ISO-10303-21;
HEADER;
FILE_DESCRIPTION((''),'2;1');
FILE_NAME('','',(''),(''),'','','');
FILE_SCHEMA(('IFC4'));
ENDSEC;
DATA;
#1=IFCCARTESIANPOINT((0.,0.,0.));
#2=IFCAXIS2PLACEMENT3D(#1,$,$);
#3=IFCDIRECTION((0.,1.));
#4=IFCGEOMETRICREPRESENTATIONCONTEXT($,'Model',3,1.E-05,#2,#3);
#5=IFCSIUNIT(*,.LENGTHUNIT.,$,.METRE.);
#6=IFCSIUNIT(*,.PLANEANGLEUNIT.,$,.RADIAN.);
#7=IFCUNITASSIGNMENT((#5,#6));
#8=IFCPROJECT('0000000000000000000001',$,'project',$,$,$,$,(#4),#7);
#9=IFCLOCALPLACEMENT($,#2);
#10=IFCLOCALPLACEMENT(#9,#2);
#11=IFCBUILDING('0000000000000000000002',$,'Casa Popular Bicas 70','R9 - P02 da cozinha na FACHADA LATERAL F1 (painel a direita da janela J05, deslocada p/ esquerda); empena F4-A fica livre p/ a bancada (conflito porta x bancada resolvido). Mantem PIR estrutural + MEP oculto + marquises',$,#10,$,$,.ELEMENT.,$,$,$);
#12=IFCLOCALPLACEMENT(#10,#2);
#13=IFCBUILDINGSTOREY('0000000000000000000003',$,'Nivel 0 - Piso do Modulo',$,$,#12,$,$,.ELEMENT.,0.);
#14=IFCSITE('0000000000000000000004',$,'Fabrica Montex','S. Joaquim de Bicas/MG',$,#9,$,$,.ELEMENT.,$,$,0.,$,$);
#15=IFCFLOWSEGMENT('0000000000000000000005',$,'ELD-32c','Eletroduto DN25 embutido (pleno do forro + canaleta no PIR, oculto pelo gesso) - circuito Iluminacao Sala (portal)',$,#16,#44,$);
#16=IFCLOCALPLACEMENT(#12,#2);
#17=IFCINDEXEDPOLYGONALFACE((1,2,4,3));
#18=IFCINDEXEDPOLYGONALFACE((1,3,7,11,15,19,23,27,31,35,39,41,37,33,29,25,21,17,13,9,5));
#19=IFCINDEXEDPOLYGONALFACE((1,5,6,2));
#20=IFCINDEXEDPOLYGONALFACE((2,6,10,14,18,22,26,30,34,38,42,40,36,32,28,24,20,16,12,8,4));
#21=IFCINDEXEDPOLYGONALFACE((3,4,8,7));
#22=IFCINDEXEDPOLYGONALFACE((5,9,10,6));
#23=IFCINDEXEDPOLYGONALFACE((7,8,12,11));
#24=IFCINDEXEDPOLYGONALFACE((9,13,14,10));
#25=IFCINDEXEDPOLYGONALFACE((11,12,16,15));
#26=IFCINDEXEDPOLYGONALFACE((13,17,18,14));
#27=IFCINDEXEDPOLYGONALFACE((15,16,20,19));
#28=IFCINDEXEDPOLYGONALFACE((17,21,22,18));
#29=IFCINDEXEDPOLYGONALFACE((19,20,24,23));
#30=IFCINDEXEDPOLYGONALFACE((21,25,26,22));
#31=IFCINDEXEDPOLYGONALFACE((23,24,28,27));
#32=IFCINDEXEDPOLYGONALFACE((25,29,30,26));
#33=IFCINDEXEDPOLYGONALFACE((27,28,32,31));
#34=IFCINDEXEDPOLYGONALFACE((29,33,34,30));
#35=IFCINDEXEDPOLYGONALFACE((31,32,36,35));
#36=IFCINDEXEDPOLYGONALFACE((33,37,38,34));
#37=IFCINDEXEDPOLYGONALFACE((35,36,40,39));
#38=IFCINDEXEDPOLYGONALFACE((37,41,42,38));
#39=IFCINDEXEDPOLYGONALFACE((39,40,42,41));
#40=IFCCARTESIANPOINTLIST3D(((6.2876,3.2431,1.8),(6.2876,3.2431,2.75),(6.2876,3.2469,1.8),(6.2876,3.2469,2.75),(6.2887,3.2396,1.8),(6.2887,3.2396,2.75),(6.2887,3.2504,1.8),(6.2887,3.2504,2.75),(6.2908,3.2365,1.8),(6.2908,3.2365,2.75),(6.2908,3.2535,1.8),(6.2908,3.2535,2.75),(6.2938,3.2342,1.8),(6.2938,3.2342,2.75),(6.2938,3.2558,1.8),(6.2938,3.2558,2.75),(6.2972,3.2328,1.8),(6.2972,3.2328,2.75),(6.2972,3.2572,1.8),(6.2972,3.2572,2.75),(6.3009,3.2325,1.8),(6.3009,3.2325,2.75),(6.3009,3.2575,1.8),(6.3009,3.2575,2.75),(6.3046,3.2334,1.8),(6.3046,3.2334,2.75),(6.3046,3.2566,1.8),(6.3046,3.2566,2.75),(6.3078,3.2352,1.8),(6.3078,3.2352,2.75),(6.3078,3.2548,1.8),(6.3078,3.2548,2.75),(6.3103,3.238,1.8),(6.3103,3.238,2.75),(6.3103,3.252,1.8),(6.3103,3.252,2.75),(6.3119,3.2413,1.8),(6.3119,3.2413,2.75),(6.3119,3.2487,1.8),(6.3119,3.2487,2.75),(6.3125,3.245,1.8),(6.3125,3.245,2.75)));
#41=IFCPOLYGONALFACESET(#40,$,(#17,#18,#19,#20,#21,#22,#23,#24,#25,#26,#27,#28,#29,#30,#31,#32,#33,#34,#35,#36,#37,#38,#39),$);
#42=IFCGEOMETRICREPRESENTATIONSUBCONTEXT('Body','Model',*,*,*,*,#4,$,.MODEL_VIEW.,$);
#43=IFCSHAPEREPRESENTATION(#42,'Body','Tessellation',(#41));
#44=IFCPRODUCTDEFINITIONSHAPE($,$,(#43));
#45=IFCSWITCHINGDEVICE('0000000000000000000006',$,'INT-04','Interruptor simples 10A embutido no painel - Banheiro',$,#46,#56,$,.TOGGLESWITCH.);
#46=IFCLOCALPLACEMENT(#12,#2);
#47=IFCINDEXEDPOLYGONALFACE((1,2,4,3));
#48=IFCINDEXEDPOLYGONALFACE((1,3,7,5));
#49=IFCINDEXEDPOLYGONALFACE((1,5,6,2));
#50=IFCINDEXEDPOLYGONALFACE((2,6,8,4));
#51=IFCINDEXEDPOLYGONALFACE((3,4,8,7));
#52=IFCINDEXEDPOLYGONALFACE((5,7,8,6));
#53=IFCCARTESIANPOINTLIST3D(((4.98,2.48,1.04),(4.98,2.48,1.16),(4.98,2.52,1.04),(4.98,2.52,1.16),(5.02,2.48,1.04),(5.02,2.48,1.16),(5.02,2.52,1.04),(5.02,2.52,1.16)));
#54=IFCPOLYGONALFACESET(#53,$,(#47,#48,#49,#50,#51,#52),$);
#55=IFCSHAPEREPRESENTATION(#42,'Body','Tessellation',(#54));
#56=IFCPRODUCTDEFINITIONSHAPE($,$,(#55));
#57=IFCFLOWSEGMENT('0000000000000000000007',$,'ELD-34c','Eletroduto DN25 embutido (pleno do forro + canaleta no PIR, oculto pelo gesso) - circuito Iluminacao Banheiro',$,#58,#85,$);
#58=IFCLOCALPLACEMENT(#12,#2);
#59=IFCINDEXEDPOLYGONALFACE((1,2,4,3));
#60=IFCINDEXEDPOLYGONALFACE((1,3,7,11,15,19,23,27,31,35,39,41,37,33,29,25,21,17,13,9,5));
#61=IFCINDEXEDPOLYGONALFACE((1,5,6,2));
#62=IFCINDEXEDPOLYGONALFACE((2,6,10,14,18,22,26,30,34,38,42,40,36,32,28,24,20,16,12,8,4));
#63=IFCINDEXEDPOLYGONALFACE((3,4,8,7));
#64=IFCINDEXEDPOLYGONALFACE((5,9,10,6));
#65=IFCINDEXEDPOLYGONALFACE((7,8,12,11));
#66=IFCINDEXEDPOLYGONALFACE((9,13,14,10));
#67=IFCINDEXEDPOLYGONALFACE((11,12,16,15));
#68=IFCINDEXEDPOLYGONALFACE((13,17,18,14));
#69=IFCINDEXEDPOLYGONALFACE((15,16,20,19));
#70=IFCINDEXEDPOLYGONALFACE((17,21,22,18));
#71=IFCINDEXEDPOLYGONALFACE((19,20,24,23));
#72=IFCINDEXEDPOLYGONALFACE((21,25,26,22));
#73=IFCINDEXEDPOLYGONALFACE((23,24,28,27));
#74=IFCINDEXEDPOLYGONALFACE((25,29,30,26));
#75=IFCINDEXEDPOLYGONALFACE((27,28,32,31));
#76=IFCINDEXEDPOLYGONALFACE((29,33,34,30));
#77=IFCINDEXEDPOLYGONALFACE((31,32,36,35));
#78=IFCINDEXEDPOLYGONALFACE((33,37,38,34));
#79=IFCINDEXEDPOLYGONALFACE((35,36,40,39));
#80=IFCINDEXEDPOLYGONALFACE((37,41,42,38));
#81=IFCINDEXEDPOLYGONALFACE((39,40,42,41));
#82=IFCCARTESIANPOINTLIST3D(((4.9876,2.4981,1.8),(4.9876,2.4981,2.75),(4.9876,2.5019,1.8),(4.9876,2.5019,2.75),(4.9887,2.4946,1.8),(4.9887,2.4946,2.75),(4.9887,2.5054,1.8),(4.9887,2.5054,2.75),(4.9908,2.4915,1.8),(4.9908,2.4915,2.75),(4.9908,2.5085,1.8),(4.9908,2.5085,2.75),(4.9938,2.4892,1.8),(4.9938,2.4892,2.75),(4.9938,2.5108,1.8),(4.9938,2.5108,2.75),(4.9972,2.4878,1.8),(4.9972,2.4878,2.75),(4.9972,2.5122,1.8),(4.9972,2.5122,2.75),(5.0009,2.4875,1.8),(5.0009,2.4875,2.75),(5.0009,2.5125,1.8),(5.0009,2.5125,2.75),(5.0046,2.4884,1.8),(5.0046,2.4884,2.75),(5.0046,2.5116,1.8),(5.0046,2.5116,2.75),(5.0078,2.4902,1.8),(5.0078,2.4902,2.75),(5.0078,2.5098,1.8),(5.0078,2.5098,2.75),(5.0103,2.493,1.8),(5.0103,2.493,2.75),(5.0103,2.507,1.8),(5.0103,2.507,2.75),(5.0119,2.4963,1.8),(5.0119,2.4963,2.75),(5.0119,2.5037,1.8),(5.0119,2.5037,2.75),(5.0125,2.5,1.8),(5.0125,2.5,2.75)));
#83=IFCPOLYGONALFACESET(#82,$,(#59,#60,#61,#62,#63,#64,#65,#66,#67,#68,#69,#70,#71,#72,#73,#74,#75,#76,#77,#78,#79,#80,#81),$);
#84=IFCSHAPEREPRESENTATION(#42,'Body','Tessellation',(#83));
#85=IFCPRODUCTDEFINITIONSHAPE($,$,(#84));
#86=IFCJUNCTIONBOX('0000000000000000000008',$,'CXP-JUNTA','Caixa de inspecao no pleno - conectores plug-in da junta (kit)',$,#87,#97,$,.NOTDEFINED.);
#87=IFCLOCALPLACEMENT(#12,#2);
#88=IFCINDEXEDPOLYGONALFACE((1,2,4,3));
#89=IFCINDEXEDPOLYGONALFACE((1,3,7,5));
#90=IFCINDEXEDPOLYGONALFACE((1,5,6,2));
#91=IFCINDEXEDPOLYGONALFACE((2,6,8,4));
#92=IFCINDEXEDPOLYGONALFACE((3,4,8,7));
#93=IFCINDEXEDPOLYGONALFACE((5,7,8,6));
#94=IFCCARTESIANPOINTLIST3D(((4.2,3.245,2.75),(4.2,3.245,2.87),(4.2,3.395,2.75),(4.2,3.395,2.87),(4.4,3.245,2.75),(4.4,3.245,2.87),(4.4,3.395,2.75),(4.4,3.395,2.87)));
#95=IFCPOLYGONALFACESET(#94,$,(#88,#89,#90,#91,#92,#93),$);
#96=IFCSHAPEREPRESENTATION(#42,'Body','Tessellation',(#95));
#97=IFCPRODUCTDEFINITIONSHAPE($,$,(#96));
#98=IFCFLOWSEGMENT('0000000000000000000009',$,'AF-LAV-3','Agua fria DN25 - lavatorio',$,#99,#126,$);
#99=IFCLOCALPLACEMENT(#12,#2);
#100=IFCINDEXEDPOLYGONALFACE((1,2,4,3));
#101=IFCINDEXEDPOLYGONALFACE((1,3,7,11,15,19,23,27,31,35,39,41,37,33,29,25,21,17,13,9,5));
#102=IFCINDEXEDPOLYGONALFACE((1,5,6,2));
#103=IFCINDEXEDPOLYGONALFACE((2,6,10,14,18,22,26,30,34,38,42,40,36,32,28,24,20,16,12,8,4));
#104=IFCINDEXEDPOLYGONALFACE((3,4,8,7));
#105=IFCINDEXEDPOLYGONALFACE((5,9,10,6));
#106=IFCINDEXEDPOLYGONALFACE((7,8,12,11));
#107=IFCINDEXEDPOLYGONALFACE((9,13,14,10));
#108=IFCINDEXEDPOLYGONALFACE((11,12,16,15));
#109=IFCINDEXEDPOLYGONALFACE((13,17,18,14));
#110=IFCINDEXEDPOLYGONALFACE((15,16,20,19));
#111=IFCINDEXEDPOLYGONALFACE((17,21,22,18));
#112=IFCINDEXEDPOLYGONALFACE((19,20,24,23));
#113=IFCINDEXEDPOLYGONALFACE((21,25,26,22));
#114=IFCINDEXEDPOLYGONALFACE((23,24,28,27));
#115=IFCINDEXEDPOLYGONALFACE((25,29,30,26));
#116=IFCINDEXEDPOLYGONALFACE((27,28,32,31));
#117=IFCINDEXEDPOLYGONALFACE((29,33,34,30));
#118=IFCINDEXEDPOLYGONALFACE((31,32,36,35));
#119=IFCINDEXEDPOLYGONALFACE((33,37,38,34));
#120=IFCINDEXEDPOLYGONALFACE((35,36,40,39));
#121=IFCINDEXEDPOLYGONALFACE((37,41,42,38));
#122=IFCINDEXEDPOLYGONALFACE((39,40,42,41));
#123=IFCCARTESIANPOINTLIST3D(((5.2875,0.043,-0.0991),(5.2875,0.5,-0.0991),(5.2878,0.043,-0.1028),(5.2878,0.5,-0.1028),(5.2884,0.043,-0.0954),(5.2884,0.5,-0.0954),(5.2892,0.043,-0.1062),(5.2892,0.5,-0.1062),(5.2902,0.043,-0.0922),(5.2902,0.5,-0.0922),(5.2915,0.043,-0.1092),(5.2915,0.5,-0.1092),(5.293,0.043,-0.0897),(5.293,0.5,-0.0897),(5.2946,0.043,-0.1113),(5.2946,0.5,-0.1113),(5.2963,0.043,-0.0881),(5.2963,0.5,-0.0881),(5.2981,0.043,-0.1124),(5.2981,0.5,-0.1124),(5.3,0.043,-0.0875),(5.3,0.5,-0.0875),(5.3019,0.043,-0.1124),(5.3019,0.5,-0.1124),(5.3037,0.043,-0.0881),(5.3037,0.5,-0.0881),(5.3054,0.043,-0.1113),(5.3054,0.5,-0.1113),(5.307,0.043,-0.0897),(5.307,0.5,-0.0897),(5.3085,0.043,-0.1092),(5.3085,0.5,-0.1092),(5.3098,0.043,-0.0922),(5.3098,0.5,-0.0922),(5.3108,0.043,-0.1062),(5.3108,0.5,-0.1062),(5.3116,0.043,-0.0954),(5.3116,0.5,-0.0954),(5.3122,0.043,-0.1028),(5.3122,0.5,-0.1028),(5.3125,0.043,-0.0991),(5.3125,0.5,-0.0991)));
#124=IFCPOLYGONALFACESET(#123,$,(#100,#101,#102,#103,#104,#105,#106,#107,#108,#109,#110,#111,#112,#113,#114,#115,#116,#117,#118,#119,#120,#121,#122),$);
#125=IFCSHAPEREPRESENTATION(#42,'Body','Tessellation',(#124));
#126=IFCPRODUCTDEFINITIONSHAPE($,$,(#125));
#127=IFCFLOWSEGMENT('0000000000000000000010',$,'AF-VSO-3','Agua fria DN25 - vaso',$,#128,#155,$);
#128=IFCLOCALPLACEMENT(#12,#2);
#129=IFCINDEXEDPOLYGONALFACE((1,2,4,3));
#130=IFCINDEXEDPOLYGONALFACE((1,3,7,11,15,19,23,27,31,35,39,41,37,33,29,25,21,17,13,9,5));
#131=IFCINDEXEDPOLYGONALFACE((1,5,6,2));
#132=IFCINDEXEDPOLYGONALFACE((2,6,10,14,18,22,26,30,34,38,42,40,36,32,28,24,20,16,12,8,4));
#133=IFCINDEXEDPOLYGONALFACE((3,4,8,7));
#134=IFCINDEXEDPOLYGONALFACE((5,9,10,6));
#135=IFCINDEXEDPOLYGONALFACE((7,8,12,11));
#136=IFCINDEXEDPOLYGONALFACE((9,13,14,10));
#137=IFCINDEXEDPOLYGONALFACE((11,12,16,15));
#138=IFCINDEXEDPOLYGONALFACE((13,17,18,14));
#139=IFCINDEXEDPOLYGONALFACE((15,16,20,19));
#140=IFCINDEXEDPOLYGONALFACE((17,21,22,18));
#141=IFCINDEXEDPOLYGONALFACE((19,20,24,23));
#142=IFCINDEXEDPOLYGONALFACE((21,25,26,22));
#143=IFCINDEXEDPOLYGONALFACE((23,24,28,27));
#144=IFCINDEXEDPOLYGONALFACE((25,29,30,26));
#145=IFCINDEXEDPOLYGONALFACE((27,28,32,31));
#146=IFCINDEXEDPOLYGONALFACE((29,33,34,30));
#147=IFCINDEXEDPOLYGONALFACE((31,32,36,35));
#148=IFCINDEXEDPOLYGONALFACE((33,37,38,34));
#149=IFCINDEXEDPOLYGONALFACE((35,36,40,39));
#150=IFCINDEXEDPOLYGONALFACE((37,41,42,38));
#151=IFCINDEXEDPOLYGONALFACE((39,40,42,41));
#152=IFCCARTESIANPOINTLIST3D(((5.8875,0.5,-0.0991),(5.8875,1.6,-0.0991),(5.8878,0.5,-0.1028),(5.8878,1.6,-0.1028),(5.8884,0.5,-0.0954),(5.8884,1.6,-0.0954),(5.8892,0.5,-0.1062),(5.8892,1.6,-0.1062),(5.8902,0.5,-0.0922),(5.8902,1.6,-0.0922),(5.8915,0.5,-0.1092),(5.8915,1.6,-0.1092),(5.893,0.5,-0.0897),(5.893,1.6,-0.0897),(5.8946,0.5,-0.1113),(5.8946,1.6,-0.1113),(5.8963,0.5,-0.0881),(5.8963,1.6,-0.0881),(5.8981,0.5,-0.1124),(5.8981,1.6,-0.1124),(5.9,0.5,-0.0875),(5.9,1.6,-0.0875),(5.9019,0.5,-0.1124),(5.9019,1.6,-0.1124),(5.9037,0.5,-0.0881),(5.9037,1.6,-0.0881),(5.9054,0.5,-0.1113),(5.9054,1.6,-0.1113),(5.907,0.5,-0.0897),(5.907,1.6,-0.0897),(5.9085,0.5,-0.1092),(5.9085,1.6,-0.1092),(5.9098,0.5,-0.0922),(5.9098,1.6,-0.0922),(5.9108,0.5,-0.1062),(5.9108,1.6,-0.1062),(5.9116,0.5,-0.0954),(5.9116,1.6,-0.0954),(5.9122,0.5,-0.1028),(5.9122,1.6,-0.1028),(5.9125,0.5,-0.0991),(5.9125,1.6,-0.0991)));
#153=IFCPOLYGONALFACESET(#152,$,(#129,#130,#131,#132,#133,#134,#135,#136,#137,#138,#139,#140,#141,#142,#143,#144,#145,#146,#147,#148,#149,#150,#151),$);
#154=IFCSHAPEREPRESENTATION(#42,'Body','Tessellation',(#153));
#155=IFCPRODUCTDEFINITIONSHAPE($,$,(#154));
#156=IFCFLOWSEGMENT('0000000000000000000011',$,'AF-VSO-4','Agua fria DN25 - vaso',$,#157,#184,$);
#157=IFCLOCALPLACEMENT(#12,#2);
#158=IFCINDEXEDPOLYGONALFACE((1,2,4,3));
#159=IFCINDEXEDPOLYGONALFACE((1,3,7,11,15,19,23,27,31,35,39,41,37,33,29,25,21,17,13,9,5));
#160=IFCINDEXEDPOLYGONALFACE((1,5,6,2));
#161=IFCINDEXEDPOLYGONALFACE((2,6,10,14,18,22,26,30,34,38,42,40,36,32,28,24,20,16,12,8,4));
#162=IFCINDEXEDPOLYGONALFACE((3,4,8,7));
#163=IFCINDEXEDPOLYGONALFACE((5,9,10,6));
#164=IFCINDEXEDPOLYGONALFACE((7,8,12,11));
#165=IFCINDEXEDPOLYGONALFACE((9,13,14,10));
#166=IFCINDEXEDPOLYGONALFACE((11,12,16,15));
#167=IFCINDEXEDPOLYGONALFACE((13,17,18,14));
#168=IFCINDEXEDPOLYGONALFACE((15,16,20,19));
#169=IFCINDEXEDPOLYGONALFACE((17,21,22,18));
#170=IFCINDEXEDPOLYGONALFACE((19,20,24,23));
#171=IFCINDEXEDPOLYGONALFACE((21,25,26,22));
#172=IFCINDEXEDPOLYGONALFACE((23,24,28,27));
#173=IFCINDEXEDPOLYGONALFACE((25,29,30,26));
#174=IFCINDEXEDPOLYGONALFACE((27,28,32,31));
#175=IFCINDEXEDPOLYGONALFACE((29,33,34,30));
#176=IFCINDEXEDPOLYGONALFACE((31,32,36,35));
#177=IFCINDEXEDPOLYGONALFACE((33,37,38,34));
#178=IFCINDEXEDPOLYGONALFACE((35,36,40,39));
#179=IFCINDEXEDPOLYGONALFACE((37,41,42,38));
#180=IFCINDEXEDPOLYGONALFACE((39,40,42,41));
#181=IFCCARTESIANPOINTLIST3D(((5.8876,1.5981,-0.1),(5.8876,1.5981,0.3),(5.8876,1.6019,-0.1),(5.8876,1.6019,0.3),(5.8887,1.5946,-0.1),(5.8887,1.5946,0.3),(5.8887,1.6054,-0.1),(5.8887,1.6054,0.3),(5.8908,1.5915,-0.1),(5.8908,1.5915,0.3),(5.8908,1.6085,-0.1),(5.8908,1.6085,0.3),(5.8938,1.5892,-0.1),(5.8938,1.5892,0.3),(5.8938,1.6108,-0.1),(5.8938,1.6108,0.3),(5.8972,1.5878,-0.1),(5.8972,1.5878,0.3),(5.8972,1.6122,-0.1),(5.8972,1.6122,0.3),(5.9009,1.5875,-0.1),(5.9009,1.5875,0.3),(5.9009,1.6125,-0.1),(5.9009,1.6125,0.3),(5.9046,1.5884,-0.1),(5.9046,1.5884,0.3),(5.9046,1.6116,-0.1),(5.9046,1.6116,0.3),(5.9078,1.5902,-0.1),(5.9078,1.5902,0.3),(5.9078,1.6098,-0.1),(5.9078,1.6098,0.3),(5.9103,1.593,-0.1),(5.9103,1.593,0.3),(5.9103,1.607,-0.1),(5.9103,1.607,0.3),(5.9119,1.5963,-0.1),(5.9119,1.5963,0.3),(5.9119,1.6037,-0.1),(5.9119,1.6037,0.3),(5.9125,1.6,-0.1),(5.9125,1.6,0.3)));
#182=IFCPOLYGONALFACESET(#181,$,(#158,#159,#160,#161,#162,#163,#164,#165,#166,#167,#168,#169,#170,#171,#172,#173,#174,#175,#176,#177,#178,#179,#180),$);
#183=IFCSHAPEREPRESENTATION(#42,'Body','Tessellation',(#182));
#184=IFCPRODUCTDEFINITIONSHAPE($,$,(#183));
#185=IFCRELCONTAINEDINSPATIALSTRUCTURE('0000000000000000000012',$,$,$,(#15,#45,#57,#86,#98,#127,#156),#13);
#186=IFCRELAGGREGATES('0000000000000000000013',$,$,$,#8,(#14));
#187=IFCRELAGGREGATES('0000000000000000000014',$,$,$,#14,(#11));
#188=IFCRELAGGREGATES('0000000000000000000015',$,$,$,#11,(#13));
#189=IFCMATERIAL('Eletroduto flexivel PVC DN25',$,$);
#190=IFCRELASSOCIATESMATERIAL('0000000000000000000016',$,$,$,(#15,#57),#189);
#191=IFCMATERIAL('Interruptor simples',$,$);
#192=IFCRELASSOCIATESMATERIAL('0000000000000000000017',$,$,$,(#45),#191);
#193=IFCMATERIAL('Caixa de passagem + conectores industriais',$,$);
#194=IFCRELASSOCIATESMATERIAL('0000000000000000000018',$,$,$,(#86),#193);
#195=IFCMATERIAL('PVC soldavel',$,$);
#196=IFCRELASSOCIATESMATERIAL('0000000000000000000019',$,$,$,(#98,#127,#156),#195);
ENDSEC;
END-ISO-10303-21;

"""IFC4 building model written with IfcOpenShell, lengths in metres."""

from ifc_helpers import new_model, si_unit, direction, frame, frame_2d, origin, origin_2d, place, context, subcontext, project, spatial, rectangle, circle, extrude, material, element, save


model = new_model("IFC4")

# Units and contexts
model_context = context("Model", 3, precision=1e-05, world=origin(), true_north=direction((0.0, 1.0)))
body_context = subcontext(model_context, "Body", "Model", "MODEL_VIEW")
ifc_project = project(units=[si_unit("LENGTHUNIT", "METRE"), si_unit("PLANEANGLEUNIT", "RADIAN")], contexts=[model_context])

# Site, building, storey
site_placement = place(None, origin())
site = spatial("IfcSite", under=ifc_project, at=site_placement, Name="Fabrica Montex", Description="S. Joaquim de Bicas/MG", CompositionType="ELEMENT", RefElevation=0.0)
building_placement = place(site_placement, origin())
building = spatial("IfcBuilding", under=site, at=building_placement, Name="Casa Popular Bicas 70", Description="R9 - P02 da cozinha na FACHADA LATERAL F1 (painel a direita da janela J05, deslocada p/ esquerda); empena F4-A fica livre p/ a bancada (conflito porta x bancada resolvido). Mantem PIR estrutural + MEP oculto + marquises", CompositionType="ELEMENT")
storey_placement = place(building_placement, origin())
storey = spatial("IfcBuildingStorey", under=building, at=storey_placement, Name="Nivel 0 - Piso do Modulo", CompositionType="ELEMENT", Elevation=0.0)

# Shared definitions
ifc_material_1 = material(Name="Eletroduto flexivel PVC DN25")

# Flow segment
flow_segment_1_placement = place(storey_placement, frame((6.3, 3.245, 2.75), z_axis=(0.0, 0.0, -1.0), x_axis=(1.0, 0.0, 0.0)))
element("IfcFlowSegment", 1, at=flow_segment_1_placement, inside=storey, material=ifc_material_1, Name="ELD-32c", Description="Eletroduto DN25 embutido (pleno do forro + canaleta no PIR, oculto pelo gesso) - circuito Iluminacao Sala (portal)", context=body_context, shape_type="SweptSolid", body=[
    extrude(circle(Radius=0.0125, at=origin_2d()), origin(), (0.0, 0.0, 1.0), 0.95),
])

# Switching device
ifc_material_2 = material(Name="Interruptor simples")
switching_device_1_placement = place(storey_placement, frame((4.98, 2.48, 1.04)))
element("IfcSwitchingDevice", 2, at=switching_device_1_placement, inside=storey, material=ifc_material_2, Name="INT-04", Description="Interruptor simples 10A embutido no painel - Banheiro", PredefinedType="TOGGLESWITCH", context=body_context, shape_type="SweptSolid", body=[
    extrude(rectangle(XDim=0.04, YDim=0.04, at=frame_2d((0.02, 0.02))), origin(), (0.0, 0.0, 1.0), 0.12),
])

# Flow segment
flow_segment_2_placement = place(storey_placement, frame((5.0, 2.5, 2.75), z_axis=(0.0, 0.0, -1.0), x_axis=(1.0, 0.0, 0.0)))
element("IfcFlowSegment", 3, at=flow_segment_2_placement, inside=storey, material=ifc_material_1, Name="ELD-34c", Description="Eletroduto DN25 embutido (pleno do forro + canaleta no PIR, oculto pelo gesso) - circuito Iluminacao Banheiro", context=body_context, shape_type="SweptSolid", body=[
    extrude(circle(Radius=0.0125, at=origin_2d()), origin(), (0.0, 0.0, 1.0), 0.95),
])

# Junction box
ifc_material_3 = material(Name="Caixa de passagem + conectores industriais")
junction_box_placement = place(storey_placement, frame((4.2, 3.245, 2.75)))
element("IfcJunctionBox", 4, at=junction_box_placement, inside=storey, material=ifc_material_3, Name="CXP-JUNTA", Description="Caixa de inspecao no pleno - conectores plug-in da junta (kit)", PredefinedType="NOTDEFINED", context=body_context, shape_type="SweptSolid", body=[
    extrude(rectangle(XDim=0.2, YDim=0.15, at=frame_2d((0.1, 0.075))), origin(), (0.0, 0.0, 1.0), 0.12),
])

# Flow segments
ifc_material_4 = material(Name="PVC soldavel")
flow_segment_3_placement = place(storey_placement, frame((5.3, 0.5, -0.1), z_axis=(0.0, -1.0, 0.0), x_axis=(0.0, 0.0, 1.0)))
element("IfcFlowSegment", 5, at=flow_segment_3_placement, inside=storey, material=ifc_material_4, Name="AF-LAV-3", Description="Agua fria DN25 - lavatorio", context=body_context, shape_type="SweptSolid", body=[
    extrude(circle(Radius=0.0125, at=origin_2d()), origin(), (0.0, 0.0, 1.0), 0.457),
])
flow_segment_4_placement = place(storey_placement, frame((5.9, 0.5, -0.1), z_axis=(0.0, 1.0, 0.0), x_axis=(0.0, 0.0, 1.0)))
element("IfcFlowSegment", 6, at=flow_segment_4_placement, inside=storey, material=ifc_material_4, Name="AF-VSO-3", Description="Agua fria DN25 - vaso", context=body_context, shape_type="SweptSolid", body=[
    extrude(circle(Radius=0.0125, at=origin_2d()), origin(), (0.0, 0.0, 1.0), 1.1),
])
flow_segment_5_placement = place(storey_placement, frame((5.9, 1.6, -0.1), z_axis=(0.0, 0.0, 1.0), x_axis=(1.0, 0.0, 0.0)))
element("IfcFlowSegment", 7, at=flow_segment_5_placement, inside=storey, material=ifc_material_4, Name="AF-VSO-4", Description="Agua fria DN25 - vaso", context=body_context, shape_type="SweptSolid", body=[
    extrude(circle(Radius=0.0125, at=origin_2d()), origin(), (0.0, 0.0, 1.0), 0.4),
])

save(model, "model.ifc")
